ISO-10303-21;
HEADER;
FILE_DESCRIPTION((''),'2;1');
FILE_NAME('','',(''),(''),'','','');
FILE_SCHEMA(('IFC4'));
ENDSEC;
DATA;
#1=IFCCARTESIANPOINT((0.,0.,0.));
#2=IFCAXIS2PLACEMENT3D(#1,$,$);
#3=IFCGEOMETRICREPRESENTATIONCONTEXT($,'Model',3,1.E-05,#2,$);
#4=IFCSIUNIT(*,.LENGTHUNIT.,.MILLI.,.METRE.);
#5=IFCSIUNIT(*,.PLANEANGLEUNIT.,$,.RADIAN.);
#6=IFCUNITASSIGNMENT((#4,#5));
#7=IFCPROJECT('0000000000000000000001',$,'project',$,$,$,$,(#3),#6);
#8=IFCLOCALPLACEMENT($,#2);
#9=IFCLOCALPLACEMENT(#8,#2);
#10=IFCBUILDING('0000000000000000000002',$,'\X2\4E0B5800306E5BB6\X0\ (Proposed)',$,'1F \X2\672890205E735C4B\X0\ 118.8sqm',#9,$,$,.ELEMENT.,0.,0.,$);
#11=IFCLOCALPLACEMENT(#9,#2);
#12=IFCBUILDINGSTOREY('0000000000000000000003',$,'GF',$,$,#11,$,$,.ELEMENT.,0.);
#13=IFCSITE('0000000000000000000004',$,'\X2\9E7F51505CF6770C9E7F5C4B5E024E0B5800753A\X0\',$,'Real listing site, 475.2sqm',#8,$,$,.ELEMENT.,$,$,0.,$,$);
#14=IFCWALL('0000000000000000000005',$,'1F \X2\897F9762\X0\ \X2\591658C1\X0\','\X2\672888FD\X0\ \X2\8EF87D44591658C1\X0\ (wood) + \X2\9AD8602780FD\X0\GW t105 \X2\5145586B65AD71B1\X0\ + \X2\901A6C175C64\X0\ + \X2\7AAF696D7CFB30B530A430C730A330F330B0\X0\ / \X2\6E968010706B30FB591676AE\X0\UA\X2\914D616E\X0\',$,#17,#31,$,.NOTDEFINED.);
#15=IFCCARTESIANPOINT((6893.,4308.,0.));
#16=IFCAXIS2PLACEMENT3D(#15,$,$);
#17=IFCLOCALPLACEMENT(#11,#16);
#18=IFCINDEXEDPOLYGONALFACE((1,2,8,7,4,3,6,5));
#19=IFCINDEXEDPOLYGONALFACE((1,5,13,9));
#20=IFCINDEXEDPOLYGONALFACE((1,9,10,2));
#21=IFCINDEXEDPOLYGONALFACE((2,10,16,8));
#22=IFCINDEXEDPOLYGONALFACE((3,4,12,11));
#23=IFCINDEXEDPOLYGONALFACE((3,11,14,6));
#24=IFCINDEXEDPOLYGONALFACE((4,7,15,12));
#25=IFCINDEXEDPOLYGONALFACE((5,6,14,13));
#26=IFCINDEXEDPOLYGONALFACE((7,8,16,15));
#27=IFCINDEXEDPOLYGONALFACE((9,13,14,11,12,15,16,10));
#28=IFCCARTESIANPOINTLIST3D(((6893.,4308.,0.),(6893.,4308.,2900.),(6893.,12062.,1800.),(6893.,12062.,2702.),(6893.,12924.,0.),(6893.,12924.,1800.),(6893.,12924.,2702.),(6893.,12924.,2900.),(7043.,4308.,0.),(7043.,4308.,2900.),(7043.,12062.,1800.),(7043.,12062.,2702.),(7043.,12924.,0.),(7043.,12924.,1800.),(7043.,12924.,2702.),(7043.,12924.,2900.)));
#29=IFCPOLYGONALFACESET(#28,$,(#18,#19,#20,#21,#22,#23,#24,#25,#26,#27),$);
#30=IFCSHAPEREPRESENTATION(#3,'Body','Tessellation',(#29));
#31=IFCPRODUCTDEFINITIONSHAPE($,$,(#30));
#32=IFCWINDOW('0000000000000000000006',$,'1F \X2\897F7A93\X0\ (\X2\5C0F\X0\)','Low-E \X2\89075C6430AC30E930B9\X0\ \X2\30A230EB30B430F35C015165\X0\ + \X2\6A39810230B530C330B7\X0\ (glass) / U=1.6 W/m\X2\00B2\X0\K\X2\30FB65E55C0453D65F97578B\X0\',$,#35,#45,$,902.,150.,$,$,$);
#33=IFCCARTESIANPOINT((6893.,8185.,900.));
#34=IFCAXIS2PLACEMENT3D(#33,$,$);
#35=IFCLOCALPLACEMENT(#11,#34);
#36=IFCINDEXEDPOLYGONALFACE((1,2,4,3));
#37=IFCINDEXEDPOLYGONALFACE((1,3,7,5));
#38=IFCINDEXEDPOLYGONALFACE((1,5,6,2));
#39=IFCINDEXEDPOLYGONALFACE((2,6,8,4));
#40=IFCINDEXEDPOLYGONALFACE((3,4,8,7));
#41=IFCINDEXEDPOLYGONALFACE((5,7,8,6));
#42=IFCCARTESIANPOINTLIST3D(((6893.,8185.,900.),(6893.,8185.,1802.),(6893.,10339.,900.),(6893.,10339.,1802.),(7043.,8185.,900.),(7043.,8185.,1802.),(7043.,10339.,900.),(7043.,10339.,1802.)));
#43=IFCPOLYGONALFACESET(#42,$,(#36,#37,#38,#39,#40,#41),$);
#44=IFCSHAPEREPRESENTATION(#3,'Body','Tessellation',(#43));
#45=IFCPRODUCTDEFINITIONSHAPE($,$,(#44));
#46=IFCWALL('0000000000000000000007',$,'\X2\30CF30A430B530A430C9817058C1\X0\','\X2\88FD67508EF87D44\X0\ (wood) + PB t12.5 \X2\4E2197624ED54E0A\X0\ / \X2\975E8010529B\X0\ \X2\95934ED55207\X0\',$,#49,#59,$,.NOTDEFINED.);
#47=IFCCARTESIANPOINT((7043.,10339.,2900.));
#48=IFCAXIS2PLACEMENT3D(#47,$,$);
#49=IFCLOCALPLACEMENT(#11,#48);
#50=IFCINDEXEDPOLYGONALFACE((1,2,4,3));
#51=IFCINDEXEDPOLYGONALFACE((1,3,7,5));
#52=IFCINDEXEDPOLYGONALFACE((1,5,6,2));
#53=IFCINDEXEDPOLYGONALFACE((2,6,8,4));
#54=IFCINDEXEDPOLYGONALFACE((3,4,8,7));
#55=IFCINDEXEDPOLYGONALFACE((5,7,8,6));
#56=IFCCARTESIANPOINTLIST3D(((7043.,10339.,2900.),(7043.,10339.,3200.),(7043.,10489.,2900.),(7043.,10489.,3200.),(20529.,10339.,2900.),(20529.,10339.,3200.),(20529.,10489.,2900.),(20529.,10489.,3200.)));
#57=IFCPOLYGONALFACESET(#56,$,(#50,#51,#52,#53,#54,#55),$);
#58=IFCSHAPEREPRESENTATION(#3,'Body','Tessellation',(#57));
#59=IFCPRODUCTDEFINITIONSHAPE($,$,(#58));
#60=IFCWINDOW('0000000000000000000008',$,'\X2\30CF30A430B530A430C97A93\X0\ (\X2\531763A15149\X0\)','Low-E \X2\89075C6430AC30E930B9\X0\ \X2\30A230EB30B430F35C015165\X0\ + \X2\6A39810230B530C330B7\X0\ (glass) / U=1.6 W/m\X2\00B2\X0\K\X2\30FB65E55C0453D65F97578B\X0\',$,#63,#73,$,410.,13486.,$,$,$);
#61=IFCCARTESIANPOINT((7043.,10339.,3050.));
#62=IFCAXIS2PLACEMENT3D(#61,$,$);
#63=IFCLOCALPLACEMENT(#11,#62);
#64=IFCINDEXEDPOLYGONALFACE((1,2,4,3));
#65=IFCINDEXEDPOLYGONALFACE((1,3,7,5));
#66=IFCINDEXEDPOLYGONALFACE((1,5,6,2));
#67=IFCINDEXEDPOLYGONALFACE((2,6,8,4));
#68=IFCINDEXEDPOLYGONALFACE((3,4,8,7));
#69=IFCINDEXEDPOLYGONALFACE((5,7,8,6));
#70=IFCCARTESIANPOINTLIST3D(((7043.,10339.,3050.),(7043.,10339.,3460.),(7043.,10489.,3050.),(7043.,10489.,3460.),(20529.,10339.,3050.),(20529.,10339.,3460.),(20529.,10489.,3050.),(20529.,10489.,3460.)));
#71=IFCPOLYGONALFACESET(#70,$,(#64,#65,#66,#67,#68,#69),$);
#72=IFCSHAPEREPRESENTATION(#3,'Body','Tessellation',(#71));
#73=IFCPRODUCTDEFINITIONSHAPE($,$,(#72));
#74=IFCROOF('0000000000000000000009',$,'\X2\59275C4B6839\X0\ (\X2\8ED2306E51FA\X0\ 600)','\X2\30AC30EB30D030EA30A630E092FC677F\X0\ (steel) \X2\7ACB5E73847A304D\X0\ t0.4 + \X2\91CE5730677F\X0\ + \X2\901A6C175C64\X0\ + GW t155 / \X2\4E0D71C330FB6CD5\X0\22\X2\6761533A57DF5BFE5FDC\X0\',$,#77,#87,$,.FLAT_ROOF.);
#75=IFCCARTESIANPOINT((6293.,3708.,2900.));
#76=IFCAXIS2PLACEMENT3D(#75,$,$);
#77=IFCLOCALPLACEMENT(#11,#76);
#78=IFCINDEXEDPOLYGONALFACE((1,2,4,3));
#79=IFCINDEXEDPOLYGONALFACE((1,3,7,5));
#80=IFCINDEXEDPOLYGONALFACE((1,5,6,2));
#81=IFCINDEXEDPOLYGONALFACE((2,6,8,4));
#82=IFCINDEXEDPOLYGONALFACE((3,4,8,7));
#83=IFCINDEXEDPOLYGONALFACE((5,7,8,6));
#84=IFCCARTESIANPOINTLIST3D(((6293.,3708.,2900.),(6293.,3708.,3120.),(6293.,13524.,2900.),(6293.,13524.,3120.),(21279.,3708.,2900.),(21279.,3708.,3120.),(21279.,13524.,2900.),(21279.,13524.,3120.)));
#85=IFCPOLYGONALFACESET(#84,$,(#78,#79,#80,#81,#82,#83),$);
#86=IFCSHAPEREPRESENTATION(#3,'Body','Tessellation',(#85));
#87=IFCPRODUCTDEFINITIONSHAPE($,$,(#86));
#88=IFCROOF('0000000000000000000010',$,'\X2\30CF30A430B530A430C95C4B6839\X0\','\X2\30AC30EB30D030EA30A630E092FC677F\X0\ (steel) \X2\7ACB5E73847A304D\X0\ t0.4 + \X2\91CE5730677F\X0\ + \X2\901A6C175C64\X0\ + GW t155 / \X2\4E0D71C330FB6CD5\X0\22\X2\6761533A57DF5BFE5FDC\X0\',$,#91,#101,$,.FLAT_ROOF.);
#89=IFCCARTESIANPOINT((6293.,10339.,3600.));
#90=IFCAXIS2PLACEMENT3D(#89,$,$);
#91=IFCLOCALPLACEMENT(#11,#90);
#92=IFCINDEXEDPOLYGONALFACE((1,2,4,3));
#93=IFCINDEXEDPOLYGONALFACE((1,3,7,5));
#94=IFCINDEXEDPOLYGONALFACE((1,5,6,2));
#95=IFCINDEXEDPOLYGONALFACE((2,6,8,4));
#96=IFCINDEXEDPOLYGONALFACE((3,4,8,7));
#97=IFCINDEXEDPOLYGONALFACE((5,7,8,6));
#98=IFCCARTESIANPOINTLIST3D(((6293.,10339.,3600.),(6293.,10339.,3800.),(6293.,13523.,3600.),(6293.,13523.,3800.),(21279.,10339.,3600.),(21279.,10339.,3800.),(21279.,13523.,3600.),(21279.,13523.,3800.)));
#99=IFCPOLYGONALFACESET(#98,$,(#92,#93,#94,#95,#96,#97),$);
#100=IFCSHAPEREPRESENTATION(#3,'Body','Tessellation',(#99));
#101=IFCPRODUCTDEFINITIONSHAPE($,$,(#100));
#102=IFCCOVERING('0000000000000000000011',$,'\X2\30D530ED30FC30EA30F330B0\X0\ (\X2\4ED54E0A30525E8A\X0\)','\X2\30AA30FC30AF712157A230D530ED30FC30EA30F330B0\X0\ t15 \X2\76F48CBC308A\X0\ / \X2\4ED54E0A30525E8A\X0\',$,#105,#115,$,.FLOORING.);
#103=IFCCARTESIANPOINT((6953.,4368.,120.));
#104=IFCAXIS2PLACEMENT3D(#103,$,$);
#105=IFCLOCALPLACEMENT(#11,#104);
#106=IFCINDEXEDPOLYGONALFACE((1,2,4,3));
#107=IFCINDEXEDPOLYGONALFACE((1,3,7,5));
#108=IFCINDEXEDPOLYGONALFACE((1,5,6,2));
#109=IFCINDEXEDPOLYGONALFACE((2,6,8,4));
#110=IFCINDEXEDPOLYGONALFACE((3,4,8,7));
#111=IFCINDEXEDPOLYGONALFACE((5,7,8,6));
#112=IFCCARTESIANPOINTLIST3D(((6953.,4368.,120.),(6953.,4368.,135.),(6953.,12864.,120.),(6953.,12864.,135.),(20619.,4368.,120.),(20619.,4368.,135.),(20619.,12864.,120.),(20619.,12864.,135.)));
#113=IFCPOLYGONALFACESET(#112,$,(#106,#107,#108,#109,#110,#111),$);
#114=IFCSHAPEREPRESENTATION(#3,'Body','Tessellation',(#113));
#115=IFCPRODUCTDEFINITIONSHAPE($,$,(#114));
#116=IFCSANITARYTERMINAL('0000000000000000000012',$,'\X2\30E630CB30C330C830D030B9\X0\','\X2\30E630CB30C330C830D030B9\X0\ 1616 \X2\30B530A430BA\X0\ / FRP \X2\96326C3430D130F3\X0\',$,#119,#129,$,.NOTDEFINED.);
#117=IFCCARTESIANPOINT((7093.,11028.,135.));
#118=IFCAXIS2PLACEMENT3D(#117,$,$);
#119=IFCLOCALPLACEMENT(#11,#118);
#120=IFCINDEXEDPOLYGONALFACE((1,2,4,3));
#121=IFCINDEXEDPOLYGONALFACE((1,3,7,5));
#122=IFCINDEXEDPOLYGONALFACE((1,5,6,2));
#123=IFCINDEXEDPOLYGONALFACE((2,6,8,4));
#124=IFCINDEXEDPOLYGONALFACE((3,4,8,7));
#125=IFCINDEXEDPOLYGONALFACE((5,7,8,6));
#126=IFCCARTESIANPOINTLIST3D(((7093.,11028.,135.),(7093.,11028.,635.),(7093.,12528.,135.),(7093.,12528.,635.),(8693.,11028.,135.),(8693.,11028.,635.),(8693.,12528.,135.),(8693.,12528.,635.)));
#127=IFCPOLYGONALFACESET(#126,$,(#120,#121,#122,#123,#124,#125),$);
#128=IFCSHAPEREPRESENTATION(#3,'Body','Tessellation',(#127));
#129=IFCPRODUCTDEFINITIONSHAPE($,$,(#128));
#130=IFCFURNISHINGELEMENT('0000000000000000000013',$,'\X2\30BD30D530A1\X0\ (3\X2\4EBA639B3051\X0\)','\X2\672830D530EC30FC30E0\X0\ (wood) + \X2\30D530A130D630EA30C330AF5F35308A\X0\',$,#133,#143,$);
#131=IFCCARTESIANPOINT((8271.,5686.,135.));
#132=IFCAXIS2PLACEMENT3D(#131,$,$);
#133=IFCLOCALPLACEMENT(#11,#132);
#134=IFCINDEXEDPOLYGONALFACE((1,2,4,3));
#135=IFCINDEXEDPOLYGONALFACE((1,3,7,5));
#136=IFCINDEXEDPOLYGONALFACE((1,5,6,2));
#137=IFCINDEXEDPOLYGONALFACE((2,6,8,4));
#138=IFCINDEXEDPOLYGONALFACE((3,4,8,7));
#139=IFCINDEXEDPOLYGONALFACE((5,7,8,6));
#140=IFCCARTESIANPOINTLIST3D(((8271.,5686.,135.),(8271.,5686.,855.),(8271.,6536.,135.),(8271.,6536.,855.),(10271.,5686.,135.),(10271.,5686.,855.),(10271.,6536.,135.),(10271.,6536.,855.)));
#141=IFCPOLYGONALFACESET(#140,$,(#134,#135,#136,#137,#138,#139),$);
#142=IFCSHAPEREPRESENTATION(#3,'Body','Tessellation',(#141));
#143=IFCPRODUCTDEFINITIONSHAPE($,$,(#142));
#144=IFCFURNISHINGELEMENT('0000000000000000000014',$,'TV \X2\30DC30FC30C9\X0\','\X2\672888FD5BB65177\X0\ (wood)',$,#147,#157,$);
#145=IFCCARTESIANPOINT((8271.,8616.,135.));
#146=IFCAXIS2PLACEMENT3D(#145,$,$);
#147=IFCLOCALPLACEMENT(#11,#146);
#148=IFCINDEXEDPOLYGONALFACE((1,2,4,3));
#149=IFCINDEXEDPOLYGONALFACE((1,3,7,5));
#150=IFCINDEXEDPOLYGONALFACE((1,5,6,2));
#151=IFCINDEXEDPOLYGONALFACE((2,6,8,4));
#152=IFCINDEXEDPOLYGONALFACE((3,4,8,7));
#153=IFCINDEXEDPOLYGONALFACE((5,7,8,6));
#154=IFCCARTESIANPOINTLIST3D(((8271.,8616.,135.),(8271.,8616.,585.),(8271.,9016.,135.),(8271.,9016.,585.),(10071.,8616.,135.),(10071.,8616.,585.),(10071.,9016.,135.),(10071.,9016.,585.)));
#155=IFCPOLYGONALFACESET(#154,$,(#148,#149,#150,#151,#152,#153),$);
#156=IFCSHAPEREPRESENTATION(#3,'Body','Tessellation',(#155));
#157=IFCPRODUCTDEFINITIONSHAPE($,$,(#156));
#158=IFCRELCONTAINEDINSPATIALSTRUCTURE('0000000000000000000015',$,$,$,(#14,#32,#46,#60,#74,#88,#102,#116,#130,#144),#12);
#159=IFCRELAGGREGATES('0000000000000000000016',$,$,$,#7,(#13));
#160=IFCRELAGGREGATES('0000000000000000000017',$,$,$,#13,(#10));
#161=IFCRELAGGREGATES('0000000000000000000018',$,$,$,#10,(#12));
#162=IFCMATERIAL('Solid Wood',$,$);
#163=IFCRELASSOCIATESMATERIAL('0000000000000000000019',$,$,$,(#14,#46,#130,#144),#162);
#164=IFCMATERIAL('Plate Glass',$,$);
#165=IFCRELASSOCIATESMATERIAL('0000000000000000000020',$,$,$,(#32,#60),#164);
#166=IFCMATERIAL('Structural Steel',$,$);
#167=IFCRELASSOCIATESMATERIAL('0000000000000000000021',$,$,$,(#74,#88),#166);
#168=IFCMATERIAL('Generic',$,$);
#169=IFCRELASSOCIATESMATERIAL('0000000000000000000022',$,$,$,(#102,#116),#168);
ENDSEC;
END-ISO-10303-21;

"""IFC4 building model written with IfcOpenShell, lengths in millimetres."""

from ifc_helpers import new_model, si_unit, frame, frame_2d, origin, place, context, project, spatial, rectangle, extrude, material, element, fill, save


model = new_model("IFC4")

# Units and contexts
model_context = context("Model", 3, precision=1e-05, world=origin())
ifc_project = project(units=[si_unit("LENGTHUNIT", "METRE", prefix="MILLI"), si_unit("PLANEANGLEUNIT", "RADIAN")], contexts=[model_context])

# Site, building, storey
site_placement = place(None, origin())
site = spatial("IfcSite", under=ifc_project, at=site_placement, Name="鹿児島県鹿屋市下堀町", ObjectType="Real listing site, 475.2sqm", CompositionType="ELEMENT", RefElevation=0.0)
building_placement = place(site_placement, origin())
building = spatial("IfcBuilding", under=site, at=building_placement, Name="下堀の家 (Proposed)", ObjectType="1F 木造平屋 118.8sqm", CompositionType="ELEMENT", ElevationOfRefHeight=0.0, ElevationOfTerrain=0.0)
storey_placement = place(building_placement, origin())
storey = spatial("IfcBuildingStorey", under=building, at=storey_placement, Name="GF", CompositionType="ELEMENT", Elevation=0.0)

# Shared definitions
ifc_material_1 = material(Name="Solid Wood")

# Shared definitions
ifc_material_2 = material(Name="Plate Glass")

# Wall, opening, window
wall_1_placement = place(storey_placement, frame((6893.0, 4308.0, 0.0)))
wall_1 = element("IfcWall", 1, at=wall_1_placement, inside=storey, material=ifc_material_1, Name="1F 西面 外壁", Description="木製 軸組外壁 (wood) + 高性能GW t105 充填断熱 + 通気層 + 窯業系サイディング / 準耐火・外皮UA配慮", PredefinedType="NOTDEFINED", context=model_context, shape_type="SweptSolid", body=[
    extrude(rectangle(XDim=150.0, YDim=8616.0, at=frame_2d((75.0, 4308.0))), frame((6893.0, 4308.0, 0.0)), (0.0, 0.0, 1.0), 2900.0),
])
opening_1_placement = place(storey_placement, frame((6893.0, 8185.0, 900.0)))
opening_1 = element("IfcOpeningElement", 2, at=opening_1_placement, cuts=wall_1, PredefinedType="NOTDEFINED", context=model_context, shape_type="SweptSolid", body=[
    extrude(rectangle(XDim=150.0, YDim=2154.0, at=frame_2d((75.0, 1077.0))), frame((6893.0, 8185.0, 900.0)), (0.0, 0.0, 1.0), 902.0),
])
window_1_placement = place(storey_placement, frame((6893.0, 8185.0, 900.0)))
window_1 = element("IfcWindow", 3, at=window_1_placement, inside=storey, material=ifc_material_2, Name="1F 西窓 (小)", Description="Low-E 複層ガラス アルゴン封入 + 樹脂サッシ (glass) / U=1.6 W/m²K・日射取得型", OverallHeight=902.0, OverallWidth=150.0, context=model_context, shape_type="SweptSolid", body=[
    extrude(rectangle(XDim=150.0, YDim=2154.0, at=frame_2d((75.0, 1077.0))), frame((6893.0, 8185.0, 900.0)), (0.0, 0.0, 1.0), 902.0),
])
fill(opening_1, window_1)

# Wall, opening, window
wall_2_placement = place(storey_placement, frame((7043.0, 10339.0, 2900.0)))
wall_2 = element("IfcWall", 4, at=wall_2_placement, inside=storey, material=ifc_material_1, Name="ハイサイド腰壁", Description="製材軸組 (wood) + PB t12.5 両面仕上 / 非耐力 間仕切", PredefinedType="NOTDEFINED", context=model_context, shape_type="SweptSolid", body=[
    extrude(rectangle(XDim=13486.0, YDim=150.0, at=frame_2d((6743.0, 75.0))), frame((7043.0, 10339.0, 2900.0)), (0.0, 0.0, 1.0), 700.0),
])
opening_2_placement = place(storey_placement, frame((7043.0, 10339.0, 3050.0)))
opening_2 = element("IfcOpeningElement", 5, at=opening_2_placement, cuts=wall_2, PredefinedType="NOTDEFINED", context=model_context, shape_type="SweptSolid", body=[
    extrude(rectangle(XDim=13486.0, YDim=150.0, at=frame_2d((6743.0, 75.0))), frame((7043.0, 10339.0, 3050.0)), (0.0, 0.0, 1.0), 410.0),
])
window_2_placement = place(storey_placement, frame((7043.0, 10339.0, 3050.0)))
window_2 = element("IfcWindow", 6, at=window_2_placement, inside=storey, material=ifc_material_2, Name="ハイサイド窓 (北採光)", Description="Low-E 複層ガラス アルゴン封入 + 樹脂サッシ (glass) / U=1.6 W/m²K・日射取得型", OverallHeight=410.0, OverallWidth=13486.0, context=model_context, shape_type="SweptSolid", body=[
    extrude(rectangle(XDim=13486.0, YDim=150.0, at=frame_2d((6743.0, 75.0))), frame((7043.0, 10339.0, 3050.0)), (0.0, 0.0, 1.0), 410.0),
])
fill(opening_2, window_2)

# Roofs
ifc_material_3 = material(Name="Structural Steel")
roof_1_placement = place(storey_placement, frame((6293.0, 3708.0, 2900.0)))
element("IfcRoof", 7, at=roof_1_placement, inside=storey, material=ifc_material_3, Name="大屋根 (軒の出 600)", Description="ガルバリウム鋼板 (steel) 立平葺き t0.4 + 野地板 + 通気層 + GW t155 / 不燃・法22条区域対応", PredefinedType="FLAT_ROOF", context=model_context, shape_type="SweptSolid", body=[
    extrude(rectangle(XDim=14986.0, YDim=9816.0, at=frame_2d((7493.0, 4908.0))), frame((6293.0, 3708.0, 2900.0)), (0.0, 0.0, 1.0), 220.0),
])
roof_2_placement = place(storey_placement, frame((6293.0, 10339.0, 3600.0)))
element("IfcRoof", 8, at=roof_2_placement, inside=storey, material=ifc_material_3, Name="ハイサイド屋根", Description="ガルバリウム鋼板 (steel) 立平葺き t0.4 + 野地板 + 通気層 + GW t155 / 不燃・法22条区域対応", PredefinedType="FLAT_ROOF", context=model_context, shape_type="SweptSolid", body=[
    extrude(rectangle(XDim=14986.0, YDim=3184.0, at=frame_2d((7493.0, 1592.0))), frame((6293.0, 10339.0, 3600.0)), (0.0, 0.0, 1.0), 200.0),
])

# Covering
ifc_material_4 = material(Name="Generic")
covering_placement = place(storey_placement, frame((6953.0, 4368.0, 120.0)))
element("IfcCovering", 9, at=covering_placement, inside=storey, material=ifc_material_4, Name="フローリング (仕上げ床)", Description="オーク無垢フローリング t15 直貼り / 仕上げ床", PredefinedType="FLOORING", context=model_context, shape_type="SweptSolid", body=[
    extrude(rectangle(XDim=13666.0, YDim=8496.0, at=frame_2d((6833.0, 4248.0))), frame((6953.0, 4368.0, 120.0)), (0.0, 0.0, 1.0), 15.0),
])

# Sanitary terminal
sanitary_terminal_placement = place(storey_placement, frame((7093.0, 11028.0, 135.0)))
element("IfcSanitaryTerminal", 10, at=sanitary_terminal_placement, inside=storey, material=ifc_material_4, Name="ユニットバス", Description="ユニットバス 1616 サイズ / FRP 防水パン", PredefinedType="NOTDEFINED", context=model_context, shape_type="SweptSolid", body=[
    extrude(rectangle(XDim=1600.0, YDim=1500.0, at=frame_2d((800.0, 750.0))), frame((7093.0, 11028.0, 135.0)), (0.0, 0.0, 1.0), 500.0),
])

# Furnishing elements
furnishing_1_placement = place(storey_placement, frame((8271.0, 5686.0, 135.0)))
element("IfcFurnishingElement", 11, at=furnishing_1_placement, inside=storey, material=ifc_material_1, Name="ソファ (3人掛け)", Description="木フレーム (wood) + ファブリック張り", context=model_context, shape_type="SweptSolid", body=[
    extrude(rectangle(XDim=2000.0, YDim=850.0, at=frame_2d((1000.0, 425.0))), frame((8271.0, 5686.0, 135.0)), (0.0, 0.0, 1.0), 720.0),
])
furnishing_2_placement = place(storey_placement, frame((8271.0, 8616.0, 135.0)))
element("IfcFurnishingElement", 12, at=furnishing_2_placement, inside=storey, material=ifc_material_1, Name="TV ボード", Description="木製家具 (wood)", context=model_context, shape_type="SweptSolid", body=[
    extrude(rectangle(XDim=1800.0, YDim=400.0, at=frame_2d((900.0, 200.0))), frame((8271.0, 8616.0, 135.0)), (0.0, 0.0, 1.0), 450.0),
])

save(model, "model.ifc")
